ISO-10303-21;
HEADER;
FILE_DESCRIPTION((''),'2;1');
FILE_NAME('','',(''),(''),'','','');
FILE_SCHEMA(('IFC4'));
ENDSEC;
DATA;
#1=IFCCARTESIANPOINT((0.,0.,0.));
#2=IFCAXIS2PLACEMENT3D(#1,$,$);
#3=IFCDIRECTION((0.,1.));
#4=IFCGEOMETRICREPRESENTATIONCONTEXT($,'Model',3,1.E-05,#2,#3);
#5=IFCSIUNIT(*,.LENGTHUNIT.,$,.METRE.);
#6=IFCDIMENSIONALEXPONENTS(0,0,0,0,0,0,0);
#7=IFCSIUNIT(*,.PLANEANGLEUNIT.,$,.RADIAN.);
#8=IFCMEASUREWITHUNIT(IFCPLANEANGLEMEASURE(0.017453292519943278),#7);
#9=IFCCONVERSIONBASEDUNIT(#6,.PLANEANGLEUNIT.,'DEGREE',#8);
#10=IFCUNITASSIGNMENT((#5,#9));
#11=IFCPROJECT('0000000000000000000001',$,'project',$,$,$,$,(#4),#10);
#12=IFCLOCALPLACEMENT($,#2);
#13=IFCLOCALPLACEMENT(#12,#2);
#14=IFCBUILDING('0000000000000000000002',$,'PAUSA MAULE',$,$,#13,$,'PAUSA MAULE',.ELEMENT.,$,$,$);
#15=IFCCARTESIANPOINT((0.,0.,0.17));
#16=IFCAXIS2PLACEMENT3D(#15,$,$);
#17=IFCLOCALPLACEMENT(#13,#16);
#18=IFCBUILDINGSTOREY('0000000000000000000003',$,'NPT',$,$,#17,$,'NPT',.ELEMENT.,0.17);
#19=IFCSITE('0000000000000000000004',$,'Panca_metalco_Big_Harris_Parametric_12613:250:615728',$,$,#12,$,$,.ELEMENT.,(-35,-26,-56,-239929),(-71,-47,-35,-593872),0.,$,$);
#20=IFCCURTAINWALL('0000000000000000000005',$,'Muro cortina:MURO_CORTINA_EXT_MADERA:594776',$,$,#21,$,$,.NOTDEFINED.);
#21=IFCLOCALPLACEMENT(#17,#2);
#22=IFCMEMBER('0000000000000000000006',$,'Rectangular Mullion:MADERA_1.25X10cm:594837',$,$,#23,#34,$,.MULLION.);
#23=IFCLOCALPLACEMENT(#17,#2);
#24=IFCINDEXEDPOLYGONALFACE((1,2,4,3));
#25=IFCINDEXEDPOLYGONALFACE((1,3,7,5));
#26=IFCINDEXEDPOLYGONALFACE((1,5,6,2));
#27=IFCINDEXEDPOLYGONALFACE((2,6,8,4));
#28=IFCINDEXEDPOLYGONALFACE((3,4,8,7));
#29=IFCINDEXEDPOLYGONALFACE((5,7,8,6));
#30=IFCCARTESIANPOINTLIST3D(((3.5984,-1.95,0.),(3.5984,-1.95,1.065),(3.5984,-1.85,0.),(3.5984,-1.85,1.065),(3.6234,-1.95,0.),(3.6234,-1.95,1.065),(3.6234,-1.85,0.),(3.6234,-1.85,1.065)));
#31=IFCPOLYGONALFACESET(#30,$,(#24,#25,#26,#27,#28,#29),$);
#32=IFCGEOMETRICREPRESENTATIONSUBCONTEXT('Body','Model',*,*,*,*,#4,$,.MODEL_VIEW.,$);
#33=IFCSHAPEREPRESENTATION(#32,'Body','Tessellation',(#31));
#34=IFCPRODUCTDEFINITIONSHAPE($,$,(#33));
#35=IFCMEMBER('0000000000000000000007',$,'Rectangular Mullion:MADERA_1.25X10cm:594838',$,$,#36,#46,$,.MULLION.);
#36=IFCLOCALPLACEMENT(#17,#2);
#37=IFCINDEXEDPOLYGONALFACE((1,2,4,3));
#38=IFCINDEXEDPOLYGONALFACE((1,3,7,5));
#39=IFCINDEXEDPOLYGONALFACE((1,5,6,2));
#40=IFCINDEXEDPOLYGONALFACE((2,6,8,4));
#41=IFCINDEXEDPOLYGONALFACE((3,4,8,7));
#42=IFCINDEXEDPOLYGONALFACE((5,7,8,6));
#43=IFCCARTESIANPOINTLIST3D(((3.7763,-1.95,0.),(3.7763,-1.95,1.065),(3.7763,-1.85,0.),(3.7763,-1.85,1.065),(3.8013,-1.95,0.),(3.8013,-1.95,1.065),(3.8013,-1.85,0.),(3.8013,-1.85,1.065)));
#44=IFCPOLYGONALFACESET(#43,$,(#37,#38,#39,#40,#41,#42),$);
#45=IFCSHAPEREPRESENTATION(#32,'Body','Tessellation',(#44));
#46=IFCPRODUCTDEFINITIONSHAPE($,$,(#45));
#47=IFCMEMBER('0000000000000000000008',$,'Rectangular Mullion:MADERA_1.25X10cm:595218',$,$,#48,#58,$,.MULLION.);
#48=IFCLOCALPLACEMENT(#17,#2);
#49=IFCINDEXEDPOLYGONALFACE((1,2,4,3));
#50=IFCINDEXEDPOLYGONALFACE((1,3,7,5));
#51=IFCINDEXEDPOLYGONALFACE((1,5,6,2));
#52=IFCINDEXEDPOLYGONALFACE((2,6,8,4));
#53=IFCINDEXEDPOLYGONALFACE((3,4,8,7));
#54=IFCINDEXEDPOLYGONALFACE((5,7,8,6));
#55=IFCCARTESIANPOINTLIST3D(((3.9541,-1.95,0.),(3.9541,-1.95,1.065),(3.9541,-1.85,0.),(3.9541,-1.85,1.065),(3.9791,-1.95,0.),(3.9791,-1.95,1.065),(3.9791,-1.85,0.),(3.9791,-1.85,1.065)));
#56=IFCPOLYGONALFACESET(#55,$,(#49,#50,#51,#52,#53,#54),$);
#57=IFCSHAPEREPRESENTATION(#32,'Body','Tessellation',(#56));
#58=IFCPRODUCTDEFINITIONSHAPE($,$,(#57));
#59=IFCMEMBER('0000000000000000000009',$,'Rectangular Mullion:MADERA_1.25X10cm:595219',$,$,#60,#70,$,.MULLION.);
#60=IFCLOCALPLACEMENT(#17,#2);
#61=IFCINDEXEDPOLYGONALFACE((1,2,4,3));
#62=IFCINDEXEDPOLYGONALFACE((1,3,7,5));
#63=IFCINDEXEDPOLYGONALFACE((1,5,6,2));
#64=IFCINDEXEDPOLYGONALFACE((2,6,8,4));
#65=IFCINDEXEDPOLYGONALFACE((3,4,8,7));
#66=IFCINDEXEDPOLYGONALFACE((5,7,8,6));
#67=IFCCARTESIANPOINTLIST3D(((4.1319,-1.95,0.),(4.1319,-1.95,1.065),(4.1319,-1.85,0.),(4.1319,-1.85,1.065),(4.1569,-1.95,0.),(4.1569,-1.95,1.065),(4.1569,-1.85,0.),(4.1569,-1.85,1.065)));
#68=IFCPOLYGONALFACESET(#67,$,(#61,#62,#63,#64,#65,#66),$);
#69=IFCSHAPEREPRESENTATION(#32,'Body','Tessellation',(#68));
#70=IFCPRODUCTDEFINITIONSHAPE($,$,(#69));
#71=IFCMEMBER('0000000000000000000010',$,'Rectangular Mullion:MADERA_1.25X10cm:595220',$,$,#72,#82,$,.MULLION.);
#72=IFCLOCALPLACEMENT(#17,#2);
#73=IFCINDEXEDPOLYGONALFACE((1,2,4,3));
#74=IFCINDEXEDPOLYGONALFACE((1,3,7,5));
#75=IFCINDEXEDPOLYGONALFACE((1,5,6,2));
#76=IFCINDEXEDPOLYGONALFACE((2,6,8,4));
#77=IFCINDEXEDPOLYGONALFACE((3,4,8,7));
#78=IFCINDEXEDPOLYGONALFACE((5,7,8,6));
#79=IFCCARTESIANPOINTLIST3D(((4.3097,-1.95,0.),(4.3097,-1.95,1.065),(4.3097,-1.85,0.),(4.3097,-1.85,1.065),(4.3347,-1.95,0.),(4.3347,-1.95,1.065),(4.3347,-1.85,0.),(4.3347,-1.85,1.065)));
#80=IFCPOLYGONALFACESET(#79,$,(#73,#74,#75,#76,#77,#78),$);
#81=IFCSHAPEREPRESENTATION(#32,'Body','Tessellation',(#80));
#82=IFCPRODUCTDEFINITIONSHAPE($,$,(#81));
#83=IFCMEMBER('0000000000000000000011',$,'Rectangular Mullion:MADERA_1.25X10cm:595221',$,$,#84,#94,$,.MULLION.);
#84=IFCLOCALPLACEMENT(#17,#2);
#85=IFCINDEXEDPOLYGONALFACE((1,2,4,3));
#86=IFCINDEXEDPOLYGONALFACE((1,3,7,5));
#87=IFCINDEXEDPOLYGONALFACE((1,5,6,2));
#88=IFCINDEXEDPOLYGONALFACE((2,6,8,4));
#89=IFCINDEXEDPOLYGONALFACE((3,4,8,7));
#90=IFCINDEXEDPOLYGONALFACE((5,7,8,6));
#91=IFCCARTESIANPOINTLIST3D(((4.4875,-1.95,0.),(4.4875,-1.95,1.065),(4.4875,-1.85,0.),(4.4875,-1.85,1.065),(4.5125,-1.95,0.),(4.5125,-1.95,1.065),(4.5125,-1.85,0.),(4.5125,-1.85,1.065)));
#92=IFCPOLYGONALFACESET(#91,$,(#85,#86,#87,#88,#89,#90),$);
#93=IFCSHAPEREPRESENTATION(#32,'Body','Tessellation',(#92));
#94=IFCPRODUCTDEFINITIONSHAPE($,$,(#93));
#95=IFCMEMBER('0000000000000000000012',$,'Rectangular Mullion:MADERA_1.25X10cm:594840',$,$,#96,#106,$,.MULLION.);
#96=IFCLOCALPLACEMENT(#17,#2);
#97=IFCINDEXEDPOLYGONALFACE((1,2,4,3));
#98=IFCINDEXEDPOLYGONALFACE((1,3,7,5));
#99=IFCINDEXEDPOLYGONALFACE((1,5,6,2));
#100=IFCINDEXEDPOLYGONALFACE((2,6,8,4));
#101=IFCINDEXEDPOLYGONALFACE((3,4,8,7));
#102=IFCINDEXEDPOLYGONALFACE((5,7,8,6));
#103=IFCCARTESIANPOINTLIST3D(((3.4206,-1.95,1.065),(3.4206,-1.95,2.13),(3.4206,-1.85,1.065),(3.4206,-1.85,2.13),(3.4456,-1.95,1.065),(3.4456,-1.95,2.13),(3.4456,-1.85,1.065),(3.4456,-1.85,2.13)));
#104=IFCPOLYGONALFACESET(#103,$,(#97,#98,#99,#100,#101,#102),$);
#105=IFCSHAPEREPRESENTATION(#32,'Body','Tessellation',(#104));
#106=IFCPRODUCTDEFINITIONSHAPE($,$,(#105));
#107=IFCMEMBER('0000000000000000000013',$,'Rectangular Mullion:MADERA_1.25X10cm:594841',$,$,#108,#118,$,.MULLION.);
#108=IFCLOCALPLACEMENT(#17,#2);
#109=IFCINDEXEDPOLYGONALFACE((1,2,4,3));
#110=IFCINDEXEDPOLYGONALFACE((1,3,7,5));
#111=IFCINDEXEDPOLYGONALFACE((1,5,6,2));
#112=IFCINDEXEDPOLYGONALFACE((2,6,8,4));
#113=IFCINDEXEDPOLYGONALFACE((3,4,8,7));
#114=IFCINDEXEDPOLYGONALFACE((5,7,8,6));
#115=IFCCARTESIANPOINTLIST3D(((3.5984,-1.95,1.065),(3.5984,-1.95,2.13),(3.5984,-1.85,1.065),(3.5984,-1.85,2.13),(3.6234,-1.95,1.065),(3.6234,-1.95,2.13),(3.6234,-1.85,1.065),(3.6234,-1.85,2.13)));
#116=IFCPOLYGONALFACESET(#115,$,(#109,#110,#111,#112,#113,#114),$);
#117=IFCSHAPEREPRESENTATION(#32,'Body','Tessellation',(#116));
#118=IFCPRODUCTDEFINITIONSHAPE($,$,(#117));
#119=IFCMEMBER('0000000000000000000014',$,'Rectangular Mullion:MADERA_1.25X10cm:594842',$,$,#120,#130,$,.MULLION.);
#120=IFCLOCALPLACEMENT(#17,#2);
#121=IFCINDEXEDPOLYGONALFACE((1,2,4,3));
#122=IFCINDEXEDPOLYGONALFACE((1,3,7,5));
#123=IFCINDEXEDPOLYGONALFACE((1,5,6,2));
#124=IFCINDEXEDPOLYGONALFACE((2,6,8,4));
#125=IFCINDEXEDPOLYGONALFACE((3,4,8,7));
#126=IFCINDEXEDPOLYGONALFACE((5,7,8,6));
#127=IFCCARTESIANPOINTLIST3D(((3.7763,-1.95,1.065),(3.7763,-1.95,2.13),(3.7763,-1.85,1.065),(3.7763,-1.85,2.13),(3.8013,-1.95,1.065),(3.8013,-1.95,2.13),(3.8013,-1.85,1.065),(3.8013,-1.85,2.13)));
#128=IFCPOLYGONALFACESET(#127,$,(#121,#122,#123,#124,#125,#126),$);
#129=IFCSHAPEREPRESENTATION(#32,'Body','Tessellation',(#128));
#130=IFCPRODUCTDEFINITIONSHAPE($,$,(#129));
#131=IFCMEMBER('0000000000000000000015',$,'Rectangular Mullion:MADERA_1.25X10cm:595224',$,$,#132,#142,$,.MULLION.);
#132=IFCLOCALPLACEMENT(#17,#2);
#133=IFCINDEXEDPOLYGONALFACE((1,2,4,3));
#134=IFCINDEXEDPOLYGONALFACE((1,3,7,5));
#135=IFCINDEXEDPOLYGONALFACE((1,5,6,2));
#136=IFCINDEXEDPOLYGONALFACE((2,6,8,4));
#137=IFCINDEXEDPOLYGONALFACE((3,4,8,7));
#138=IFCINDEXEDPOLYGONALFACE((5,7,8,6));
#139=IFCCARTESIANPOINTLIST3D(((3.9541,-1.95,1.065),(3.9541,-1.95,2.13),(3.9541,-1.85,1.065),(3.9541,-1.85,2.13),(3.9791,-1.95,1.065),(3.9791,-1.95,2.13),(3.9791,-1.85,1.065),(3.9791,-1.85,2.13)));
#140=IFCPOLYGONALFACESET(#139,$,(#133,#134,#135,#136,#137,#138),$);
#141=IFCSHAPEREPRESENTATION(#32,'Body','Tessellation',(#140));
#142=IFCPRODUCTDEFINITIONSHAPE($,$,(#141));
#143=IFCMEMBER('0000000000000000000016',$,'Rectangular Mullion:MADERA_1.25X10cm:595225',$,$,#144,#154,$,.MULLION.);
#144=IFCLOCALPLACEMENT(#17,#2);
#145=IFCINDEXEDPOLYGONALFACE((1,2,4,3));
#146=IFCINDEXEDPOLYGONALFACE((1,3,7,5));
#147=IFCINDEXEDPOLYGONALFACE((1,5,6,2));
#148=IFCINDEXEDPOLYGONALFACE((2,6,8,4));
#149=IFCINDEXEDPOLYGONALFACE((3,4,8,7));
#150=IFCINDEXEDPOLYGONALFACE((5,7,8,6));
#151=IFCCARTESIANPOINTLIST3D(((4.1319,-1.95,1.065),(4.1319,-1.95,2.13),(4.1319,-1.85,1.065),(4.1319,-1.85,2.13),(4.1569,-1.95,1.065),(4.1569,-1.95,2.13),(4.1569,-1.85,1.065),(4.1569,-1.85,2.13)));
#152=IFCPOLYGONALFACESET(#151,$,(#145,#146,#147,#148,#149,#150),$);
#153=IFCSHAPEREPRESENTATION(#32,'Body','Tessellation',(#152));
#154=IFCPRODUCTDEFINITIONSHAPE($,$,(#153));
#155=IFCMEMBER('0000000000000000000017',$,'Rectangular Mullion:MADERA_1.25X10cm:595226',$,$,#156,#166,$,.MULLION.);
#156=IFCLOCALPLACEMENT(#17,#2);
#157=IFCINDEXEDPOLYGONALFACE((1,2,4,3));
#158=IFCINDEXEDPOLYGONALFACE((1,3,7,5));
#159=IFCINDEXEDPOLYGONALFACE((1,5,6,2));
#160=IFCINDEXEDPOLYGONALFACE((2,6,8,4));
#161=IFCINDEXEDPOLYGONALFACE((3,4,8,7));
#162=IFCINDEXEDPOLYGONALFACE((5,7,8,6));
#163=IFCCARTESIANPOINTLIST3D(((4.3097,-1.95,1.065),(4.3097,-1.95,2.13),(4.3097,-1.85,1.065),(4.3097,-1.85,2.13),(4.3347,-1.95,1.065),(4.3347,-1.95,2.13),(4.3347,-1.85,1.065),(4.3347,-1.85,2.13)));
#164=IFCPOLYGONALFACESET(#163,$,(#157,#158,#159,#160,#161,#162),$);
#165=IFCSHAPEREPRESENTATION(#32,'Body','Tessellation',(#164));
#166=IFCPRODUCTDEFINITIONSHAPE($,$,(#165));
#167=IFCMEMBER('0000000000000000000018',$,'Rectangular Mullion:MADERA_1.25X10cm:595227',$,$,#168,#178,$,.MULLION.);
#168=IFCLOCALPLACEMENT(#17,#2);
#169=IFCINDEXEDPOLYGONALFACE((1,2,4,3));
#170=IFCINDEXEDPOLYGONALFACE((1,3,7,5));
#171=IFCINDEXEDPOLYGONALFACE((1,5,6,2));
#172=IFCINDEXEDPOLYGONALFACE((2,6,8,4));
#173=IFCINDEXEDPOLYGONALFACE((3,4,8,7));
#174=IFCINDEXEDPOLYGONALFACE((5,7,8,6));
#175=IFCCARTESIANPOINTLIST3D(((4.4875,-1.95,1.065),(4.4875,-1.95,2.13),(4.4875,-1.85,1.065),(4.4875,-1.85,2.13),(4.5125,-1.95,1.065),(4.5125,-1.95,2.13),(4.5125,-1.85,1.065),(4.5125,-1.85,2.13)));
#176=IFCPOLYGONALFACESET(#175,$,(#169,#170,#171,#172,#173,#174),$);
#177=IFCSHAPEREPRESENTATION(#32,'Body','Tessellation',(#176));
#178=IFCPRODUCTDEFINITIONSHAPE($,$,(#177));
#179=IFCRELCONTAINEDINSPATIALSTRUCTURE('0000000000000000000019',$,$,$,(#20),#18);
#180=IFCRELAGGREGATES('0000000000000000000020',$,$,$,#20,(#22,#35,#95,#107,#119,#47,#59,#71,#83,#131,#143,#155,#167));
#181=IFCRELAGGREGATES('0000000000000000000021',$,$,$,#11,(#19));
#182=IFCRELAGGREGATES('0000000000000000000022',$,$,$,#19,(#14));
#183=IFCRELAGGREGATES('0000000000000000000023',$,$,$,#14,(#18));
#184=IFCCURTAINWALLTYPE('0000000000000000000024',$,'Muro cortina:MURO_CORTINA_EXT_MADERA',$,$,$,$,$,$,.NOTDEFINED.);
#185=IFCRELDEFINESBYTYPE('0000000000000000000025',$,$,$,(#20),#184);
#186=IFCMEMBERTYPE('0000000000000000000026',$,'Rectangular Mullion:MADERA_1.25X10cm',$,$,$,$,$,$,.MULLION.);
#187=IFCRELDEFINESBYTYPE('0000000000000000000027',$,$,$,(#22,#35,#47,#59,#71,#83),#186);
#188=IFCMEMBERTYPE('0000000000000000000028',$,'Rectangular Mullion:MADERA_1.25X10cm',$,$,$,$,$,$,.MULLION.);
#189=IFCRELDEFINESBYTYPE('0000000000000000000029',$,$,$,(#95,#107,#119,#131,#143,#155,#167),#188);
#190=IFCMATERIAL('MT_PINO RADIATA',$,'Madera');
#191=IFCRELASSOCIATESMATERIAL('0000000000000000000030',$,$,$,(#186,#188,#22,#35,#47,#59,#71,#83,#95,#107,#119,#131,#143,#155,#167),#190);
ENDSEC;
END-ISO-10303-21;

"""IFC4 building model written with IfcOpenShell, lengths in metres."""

from ifc_helpers import new_model, entity, si_unit, converted_unit, direction, frame, frame_2d, origin, place, context, subcontext, project, spatial, rectangle, extrude, source, transform, mapped, material, material_profile, profile_set, profile_usage, type_object, type_shapes, element, aggregate, save


model = new_model("IFC4")

# Units and contexts
model_context = context("Model", 3, precision=1e-05, world=origin(), true_north=direction((0.0, 1.0)))
body_context = subcontext(model_context, "Body", "Model", "MODEL_VIEW")
ifc_project = project(units=[si_unit("LENGTHUNIT", "METRE"), converted_unit("PLANEANGLEUNIT", "DEGREE", entity("IfcPlaneAngleMeasure", 0.017453292519943278), si_unit("PLANEANGLEUNIT", "RADIAN"), dimensions=[0, 0, 0, 0, 0, 0, 0])], contexts=[model_context])

# Site, building, storey
site_placement = place(None, origin())
site = spatial("IfcSite", under=ifc_project, at=site_placement, Name="Panca_metalco_Big_Harris_Parametric_12613:250:615728", CompositionType="ELEMENT", RefLatitude=(-35, -26, -56, -239929), RefLongitude=(-71, -47, -35, -593872), RefElevation=0.0)
building_placement = place(site_placement, origin())
building = spatial("IfcBuilding", under=site, at=building_placement, Name="PAUSA MAULE", LongName="PAUSA MAULE", CompositionType="ELEMENT")
storey_placement = place(building_placement, frame((0.0, 0.0, 0.17)))
storey = spatial("IfcBuildingStorey", under=building, at=storey_placement, Name="NPT", LongName="NPT", CompositionType="ELEMENT", Elevation=0.17)

# Curtain wall, members
curtain_wall_type = type_object("IfcCurtainWallType", Name="Muro cortina:MURO_CORTINA_EXT_MADERA", PredefinedType="NOTDEFINED")
curtain_wall_placement = place(storey_placement, frame((0.0, 0.0, -0.17)))
curtain_wall = element("IfcCurtainWall", 1, at=curtain_wall_placement, inside=storey, type_object=curtain_wall_type, Name="Muro cortina:MURO_CORTINA_EXT_MADERA:594776", PredefinedType="NOTDEFINED")
ifc_material = material(Name="MT_PINO RADIATA", Category="Madera")
ifc_material_profile = material_profile(ifc_material, rectangle(XDim=0.025, YDim=0.1, at=frame_2d((0.0, 0.0), x_axis=(1.0, 0.0))), Name="MADERA_1.25X10cm")
ifc_profile_set = profile_set([ifc_material_profile], Name="MADERA_1.25X10cm")
ifc_profile_usage = profile_usage(ifc_profile_set)
member_type_1 = type_object("IfcMemberType", Name="Rectangular Mullion:MADERA_1.25X10cm", PredefinedType="MULLION", material=ifc_profile_set)
shared_shape_1 = source(origin(), body_context, "Body", "SweptSolid", [
    extrude(rectangle(XDim=0.025, YDim=0.1, at=frame_2d((0.0, 0.0), x_axis=(1.0, 0.0))), frame((0.0, 0.0, -1.065), z_axis=(0.0, 0.0, 1.0), x_axis=(-1.0, 0.0, 0.0)), (0.0, 0.0, 1.0), 1.065),
])
type_shapes(member_type_1, [shared_shape_1])
member_1_placement = place(curtain_wall_placement, frame((3.6109, -1.9, 0.17), z_axis=(0.0, 0.0, -1.0), x_axis=(1.0, 0.0, 0.0)))
member_1 = element("IfcMember", 2, at=member_1_placement, type_object=member_type_1, material=ifc_profile_usage, Name="Rectangular Mullion:MADERA_1.25X10cm:594837", PredefinedType="MULLION", context=body_context, shape_type="MappedRepresentation", body=[
    mapped(shared_shape_1, transform((0.0, 0.0, 0.0), scale=1.0)),
])
member_2_placement = place(curtain_wall_placement, frame((3.7888, -1.9, 0.17), z_axis=(0.0, 0.0, -1.0), x_axis=(1.0, 0.0, 0.0)))
member_2 = element("IfcMember", 3, at=member_2_placement, type_object=member_type_1, material=ifc_profile_usage, Name="Rectangular Mullion:MADERA_1.25X10cm:594838", PredefinedType="MULLION", context=body_context, shape_type="MappedRepresentation", body=[
    mapped(shared_shape_1, transform((0.0, 0.0, 0.0), scale=1.0)),
])
member_3_placement = place(curtain_wall_placement, frame((3.9666, -1.9, 0.17), z_axis=(0.0, 0.0, -1.0), x_axis=(1.0, 0.0, 0.0)))
member_3 = element("IfcMember", 4, at=member_3_placement, type_object=member_type_1, material=ifc_profile_usage, Name="Rectangular Mullion:MADERA_1.25X10cm:595218", PredefinedType="MULLION", context=body_context, shape_type="MappedRepresentation", body=[
    mapped(shared_shape_1, transform((0.0, 0.0, 0.0), scale=1.0)),
])
member_4_placement = place(curtain_wall_placement, frame((4.1444, -1.9, 0.17), z_axis=(0.0, 0.0, -1.0), x_axis=(1.0, 0.0, 0.0)))
member_4 = element("IfcMember", 5, at=member_4_placement, type_object=member_type_1, material=ifc_profile_usage, Name="Rectangular Mullion:MADERA_1.25X10cm:595219", PredefinedType="MULLION", context=body_context, shape_type="MappedRepresentation", body=[
    mapped(shared_shape_1, transform((0.0, 0.0, 0.0), scale=1.0)),
])
member_5_placement = place(curtain_wall_placement, frame((4.3222, -1.9, 0.17), z_axis=(0.0, 0.0, -1.0), x_axis=(1.0, 0.0, 0.0)))
member_5 = element("IfcMember", 6, at=member_5_placement, type_object=member_type_1, material=ifc_profile_usage, Name="Rectangular Mullion:MADERA_1.25X10cm:595220", PredefinedType="MULLION", context=body_context, shape_type="MappedRepresentation", body=[
    mapped(shared_shape_1, transform((0.0, 0.0, 0.0), scale=1.0)),
])
member_6_placement = place(curtain_wall_placement, frame((4.5, -1.9, 0.17), z_axis=(0.0, 0.0, -1.0), x_axis=(1.0, 0.0, 0.0)))
member_6 = element("IfcMember", 7, at=member_6_placement, type_object=member_type_1, material=ifc_profile_usage, Name="Rectangular Mullion:MADERA_1.25X10cm:595221", PredefinedType="MULLION", context=body_context, shape_type="MappedRepresentation", body=[
    mapped(shared_shape_1, transform((0.0, 0.0, 0.0), scale=1.0)),
])
member_type_2 = type_object("IfcMemberType", Name="Rectangular Mullion:MADERA_1.25X10cm", PredefinedType="MULLION", material=ifc_profile_set)
shared_shape_2 = source(origin(), body_context, "Body", "SweptSolid", [
    extrude(rectangle(XDim=0.025, YDim=0.1, at=frame_2d((0.0, 0.0), x_axis=(1.0, 0.0))), frame((0.0, 0.0, -1.065), z_axis=(0.0, 0.0, 1.0), x_axis=(-1.0, 0.0, 0.0)), (0.0, 0.0, 1.0), 1.065),
])
type_shapes(member_type_2, [shared_shape_2])
member_7_placement = place(curtain_wall_placement, frame((3.4331, -1.9, 1.235), z_axis=(0.0, 0.0, -1.0), x_axis=(1.0, 0.0, 0.0)))
member_7 = element("IfcMember", 8, at=member_7_placement, type_object=member_type_2, material=ifc_profile_usage, Name="Rectangular Mullion:MADERA_1.25X10cm:594840", PredefinedType="MULLION", context=body_context, shape_type="MappedRepresentation", body=[
    mapped(shared_shape_2, transform((0.0, 0.0, 0.0), scale=1.0)),
])
member_8_placement = place(curtain_wall_placement, frame((3.6109, -1.9, 1.235), z_axis=(0.0, 0.0, -1.0), x_axis=(1.0, 0.0, 0.0)))
member_8 = element("IfcMember", 9, at=member_8_placement, type_object=member_type_2, material=ifc_profile_usage, Name="Rectangular Mullion:MADERA_1.25X10cm:594841", PredefinedType="MULLION", context=body_context, shape_type="MappedRepresentation", body=[
    mapped(shared_shape_2, transform((0.0, 0.0, 0.0), scale=1.0)),
])
member_9_placement = place(curtain_wall_placement, frame((3.7888, -1.9, 1.235), z_axis=(0.0, 0.0, -1.0), x_axis=(1.0, 0.0, 0.0)))
member_9 = element("IfcMember", 10, at=member_9_placement, type_object=member_type_2, material=ifc_profile_usage, Name="Rectangular Mullion:MADERA_1.25X10cm:594842", PredefinedType="MULLION", context=body_context, shape_type="MappedRepresentation", body=[
    mapped(shared_shape_2, transform((0.0, 0.0, 0.0), scale=1.0)),
])
member_10_placement = place(curtain_wall_placement, frame((3.9666, -1.9, 1.235), z_axis=(0.0, 0.0, -1.0), x_axis=(1.0, 0.0, 0.0)))
member_10 = element("IfcMember", 11, at=member_10_placement, type_object=member_type_2, material=ifc_profile_usage, Name="Rectangular Mullion:MADERA_1.25X10cm:595224", PredefinedType="MULLION", context=body_context, shape_type="MappedRepresentation", body=[
    mapped(shared_shape_2, transform((0.0, 0.0, 0.0), scale=1.0)),
])
member_11_placement = place(curtain_wall_placement, frame((4.1444, -1.9, 1.235), z_axis=(0.0, 0.0, -1.0), x_axis=(1.0, 0.0, 0.0)))
member_11 = element("IfcMember", 12, at=member_11_placement, type_object=member_type_2, material=ifc_profile_usage, Name="Rectangular Mullion:MADERA_1.25X10cm:595225", PredefinedType="MULLION", context=body_context, shape_type="MappedRepresentation", body=[
    mapped(shared_shape_2, transform((0.0, 0.0, 0.0), scale=1.0)),
])
member_12_placement = place(curtain_wall_placement, frame((4.3222, -1.9, 1.235), z_axis=(0.0, 0.0, -1.0), x_axis=(1.0, 0.0, 0.0)))
member_12 = element("IfcMember", 13, at=member_12_placement, type_object=member_type_2, material=ifc_profile_usage, Name="Rectangular Mullion:MADERA_1.25X10cm:595226", PredefinedType="MULLION", context=body_context, shape_type="MappedRepresentation", body=[
    mapped(shared_shape_2, transform((0.0, 0.0, 0.0), scale=1.0)),
])
member_13_placement = place(curtain_wall_placement, frame((4.5, -1.9, 1.235), z_axis=(0.0, 0.0, -1.0), x_axis=(1.0, 0.0, 0.0)))
member_13 = element("IfcMember", 14, at=member_13_placement, type_object=member_type_2, material=ifc_profile_usage, Name="Rectangular Mullion:MADERA_1.25X10cm:595227", PredefinedType="MULLION", context=body_context, shape_type="MappedRepresentation", body=[
    mapped(shared_shape_2, transform((0.0, 0.0, 0.0), scale=1.0)),
])
aggregate(curtain_wall, [member_1, member_2, member_7, member_8, member_9, member_3, member_4, member_5, member_6, member_10, member_11, member_12, member_13])

save(model, "model.ifc")
